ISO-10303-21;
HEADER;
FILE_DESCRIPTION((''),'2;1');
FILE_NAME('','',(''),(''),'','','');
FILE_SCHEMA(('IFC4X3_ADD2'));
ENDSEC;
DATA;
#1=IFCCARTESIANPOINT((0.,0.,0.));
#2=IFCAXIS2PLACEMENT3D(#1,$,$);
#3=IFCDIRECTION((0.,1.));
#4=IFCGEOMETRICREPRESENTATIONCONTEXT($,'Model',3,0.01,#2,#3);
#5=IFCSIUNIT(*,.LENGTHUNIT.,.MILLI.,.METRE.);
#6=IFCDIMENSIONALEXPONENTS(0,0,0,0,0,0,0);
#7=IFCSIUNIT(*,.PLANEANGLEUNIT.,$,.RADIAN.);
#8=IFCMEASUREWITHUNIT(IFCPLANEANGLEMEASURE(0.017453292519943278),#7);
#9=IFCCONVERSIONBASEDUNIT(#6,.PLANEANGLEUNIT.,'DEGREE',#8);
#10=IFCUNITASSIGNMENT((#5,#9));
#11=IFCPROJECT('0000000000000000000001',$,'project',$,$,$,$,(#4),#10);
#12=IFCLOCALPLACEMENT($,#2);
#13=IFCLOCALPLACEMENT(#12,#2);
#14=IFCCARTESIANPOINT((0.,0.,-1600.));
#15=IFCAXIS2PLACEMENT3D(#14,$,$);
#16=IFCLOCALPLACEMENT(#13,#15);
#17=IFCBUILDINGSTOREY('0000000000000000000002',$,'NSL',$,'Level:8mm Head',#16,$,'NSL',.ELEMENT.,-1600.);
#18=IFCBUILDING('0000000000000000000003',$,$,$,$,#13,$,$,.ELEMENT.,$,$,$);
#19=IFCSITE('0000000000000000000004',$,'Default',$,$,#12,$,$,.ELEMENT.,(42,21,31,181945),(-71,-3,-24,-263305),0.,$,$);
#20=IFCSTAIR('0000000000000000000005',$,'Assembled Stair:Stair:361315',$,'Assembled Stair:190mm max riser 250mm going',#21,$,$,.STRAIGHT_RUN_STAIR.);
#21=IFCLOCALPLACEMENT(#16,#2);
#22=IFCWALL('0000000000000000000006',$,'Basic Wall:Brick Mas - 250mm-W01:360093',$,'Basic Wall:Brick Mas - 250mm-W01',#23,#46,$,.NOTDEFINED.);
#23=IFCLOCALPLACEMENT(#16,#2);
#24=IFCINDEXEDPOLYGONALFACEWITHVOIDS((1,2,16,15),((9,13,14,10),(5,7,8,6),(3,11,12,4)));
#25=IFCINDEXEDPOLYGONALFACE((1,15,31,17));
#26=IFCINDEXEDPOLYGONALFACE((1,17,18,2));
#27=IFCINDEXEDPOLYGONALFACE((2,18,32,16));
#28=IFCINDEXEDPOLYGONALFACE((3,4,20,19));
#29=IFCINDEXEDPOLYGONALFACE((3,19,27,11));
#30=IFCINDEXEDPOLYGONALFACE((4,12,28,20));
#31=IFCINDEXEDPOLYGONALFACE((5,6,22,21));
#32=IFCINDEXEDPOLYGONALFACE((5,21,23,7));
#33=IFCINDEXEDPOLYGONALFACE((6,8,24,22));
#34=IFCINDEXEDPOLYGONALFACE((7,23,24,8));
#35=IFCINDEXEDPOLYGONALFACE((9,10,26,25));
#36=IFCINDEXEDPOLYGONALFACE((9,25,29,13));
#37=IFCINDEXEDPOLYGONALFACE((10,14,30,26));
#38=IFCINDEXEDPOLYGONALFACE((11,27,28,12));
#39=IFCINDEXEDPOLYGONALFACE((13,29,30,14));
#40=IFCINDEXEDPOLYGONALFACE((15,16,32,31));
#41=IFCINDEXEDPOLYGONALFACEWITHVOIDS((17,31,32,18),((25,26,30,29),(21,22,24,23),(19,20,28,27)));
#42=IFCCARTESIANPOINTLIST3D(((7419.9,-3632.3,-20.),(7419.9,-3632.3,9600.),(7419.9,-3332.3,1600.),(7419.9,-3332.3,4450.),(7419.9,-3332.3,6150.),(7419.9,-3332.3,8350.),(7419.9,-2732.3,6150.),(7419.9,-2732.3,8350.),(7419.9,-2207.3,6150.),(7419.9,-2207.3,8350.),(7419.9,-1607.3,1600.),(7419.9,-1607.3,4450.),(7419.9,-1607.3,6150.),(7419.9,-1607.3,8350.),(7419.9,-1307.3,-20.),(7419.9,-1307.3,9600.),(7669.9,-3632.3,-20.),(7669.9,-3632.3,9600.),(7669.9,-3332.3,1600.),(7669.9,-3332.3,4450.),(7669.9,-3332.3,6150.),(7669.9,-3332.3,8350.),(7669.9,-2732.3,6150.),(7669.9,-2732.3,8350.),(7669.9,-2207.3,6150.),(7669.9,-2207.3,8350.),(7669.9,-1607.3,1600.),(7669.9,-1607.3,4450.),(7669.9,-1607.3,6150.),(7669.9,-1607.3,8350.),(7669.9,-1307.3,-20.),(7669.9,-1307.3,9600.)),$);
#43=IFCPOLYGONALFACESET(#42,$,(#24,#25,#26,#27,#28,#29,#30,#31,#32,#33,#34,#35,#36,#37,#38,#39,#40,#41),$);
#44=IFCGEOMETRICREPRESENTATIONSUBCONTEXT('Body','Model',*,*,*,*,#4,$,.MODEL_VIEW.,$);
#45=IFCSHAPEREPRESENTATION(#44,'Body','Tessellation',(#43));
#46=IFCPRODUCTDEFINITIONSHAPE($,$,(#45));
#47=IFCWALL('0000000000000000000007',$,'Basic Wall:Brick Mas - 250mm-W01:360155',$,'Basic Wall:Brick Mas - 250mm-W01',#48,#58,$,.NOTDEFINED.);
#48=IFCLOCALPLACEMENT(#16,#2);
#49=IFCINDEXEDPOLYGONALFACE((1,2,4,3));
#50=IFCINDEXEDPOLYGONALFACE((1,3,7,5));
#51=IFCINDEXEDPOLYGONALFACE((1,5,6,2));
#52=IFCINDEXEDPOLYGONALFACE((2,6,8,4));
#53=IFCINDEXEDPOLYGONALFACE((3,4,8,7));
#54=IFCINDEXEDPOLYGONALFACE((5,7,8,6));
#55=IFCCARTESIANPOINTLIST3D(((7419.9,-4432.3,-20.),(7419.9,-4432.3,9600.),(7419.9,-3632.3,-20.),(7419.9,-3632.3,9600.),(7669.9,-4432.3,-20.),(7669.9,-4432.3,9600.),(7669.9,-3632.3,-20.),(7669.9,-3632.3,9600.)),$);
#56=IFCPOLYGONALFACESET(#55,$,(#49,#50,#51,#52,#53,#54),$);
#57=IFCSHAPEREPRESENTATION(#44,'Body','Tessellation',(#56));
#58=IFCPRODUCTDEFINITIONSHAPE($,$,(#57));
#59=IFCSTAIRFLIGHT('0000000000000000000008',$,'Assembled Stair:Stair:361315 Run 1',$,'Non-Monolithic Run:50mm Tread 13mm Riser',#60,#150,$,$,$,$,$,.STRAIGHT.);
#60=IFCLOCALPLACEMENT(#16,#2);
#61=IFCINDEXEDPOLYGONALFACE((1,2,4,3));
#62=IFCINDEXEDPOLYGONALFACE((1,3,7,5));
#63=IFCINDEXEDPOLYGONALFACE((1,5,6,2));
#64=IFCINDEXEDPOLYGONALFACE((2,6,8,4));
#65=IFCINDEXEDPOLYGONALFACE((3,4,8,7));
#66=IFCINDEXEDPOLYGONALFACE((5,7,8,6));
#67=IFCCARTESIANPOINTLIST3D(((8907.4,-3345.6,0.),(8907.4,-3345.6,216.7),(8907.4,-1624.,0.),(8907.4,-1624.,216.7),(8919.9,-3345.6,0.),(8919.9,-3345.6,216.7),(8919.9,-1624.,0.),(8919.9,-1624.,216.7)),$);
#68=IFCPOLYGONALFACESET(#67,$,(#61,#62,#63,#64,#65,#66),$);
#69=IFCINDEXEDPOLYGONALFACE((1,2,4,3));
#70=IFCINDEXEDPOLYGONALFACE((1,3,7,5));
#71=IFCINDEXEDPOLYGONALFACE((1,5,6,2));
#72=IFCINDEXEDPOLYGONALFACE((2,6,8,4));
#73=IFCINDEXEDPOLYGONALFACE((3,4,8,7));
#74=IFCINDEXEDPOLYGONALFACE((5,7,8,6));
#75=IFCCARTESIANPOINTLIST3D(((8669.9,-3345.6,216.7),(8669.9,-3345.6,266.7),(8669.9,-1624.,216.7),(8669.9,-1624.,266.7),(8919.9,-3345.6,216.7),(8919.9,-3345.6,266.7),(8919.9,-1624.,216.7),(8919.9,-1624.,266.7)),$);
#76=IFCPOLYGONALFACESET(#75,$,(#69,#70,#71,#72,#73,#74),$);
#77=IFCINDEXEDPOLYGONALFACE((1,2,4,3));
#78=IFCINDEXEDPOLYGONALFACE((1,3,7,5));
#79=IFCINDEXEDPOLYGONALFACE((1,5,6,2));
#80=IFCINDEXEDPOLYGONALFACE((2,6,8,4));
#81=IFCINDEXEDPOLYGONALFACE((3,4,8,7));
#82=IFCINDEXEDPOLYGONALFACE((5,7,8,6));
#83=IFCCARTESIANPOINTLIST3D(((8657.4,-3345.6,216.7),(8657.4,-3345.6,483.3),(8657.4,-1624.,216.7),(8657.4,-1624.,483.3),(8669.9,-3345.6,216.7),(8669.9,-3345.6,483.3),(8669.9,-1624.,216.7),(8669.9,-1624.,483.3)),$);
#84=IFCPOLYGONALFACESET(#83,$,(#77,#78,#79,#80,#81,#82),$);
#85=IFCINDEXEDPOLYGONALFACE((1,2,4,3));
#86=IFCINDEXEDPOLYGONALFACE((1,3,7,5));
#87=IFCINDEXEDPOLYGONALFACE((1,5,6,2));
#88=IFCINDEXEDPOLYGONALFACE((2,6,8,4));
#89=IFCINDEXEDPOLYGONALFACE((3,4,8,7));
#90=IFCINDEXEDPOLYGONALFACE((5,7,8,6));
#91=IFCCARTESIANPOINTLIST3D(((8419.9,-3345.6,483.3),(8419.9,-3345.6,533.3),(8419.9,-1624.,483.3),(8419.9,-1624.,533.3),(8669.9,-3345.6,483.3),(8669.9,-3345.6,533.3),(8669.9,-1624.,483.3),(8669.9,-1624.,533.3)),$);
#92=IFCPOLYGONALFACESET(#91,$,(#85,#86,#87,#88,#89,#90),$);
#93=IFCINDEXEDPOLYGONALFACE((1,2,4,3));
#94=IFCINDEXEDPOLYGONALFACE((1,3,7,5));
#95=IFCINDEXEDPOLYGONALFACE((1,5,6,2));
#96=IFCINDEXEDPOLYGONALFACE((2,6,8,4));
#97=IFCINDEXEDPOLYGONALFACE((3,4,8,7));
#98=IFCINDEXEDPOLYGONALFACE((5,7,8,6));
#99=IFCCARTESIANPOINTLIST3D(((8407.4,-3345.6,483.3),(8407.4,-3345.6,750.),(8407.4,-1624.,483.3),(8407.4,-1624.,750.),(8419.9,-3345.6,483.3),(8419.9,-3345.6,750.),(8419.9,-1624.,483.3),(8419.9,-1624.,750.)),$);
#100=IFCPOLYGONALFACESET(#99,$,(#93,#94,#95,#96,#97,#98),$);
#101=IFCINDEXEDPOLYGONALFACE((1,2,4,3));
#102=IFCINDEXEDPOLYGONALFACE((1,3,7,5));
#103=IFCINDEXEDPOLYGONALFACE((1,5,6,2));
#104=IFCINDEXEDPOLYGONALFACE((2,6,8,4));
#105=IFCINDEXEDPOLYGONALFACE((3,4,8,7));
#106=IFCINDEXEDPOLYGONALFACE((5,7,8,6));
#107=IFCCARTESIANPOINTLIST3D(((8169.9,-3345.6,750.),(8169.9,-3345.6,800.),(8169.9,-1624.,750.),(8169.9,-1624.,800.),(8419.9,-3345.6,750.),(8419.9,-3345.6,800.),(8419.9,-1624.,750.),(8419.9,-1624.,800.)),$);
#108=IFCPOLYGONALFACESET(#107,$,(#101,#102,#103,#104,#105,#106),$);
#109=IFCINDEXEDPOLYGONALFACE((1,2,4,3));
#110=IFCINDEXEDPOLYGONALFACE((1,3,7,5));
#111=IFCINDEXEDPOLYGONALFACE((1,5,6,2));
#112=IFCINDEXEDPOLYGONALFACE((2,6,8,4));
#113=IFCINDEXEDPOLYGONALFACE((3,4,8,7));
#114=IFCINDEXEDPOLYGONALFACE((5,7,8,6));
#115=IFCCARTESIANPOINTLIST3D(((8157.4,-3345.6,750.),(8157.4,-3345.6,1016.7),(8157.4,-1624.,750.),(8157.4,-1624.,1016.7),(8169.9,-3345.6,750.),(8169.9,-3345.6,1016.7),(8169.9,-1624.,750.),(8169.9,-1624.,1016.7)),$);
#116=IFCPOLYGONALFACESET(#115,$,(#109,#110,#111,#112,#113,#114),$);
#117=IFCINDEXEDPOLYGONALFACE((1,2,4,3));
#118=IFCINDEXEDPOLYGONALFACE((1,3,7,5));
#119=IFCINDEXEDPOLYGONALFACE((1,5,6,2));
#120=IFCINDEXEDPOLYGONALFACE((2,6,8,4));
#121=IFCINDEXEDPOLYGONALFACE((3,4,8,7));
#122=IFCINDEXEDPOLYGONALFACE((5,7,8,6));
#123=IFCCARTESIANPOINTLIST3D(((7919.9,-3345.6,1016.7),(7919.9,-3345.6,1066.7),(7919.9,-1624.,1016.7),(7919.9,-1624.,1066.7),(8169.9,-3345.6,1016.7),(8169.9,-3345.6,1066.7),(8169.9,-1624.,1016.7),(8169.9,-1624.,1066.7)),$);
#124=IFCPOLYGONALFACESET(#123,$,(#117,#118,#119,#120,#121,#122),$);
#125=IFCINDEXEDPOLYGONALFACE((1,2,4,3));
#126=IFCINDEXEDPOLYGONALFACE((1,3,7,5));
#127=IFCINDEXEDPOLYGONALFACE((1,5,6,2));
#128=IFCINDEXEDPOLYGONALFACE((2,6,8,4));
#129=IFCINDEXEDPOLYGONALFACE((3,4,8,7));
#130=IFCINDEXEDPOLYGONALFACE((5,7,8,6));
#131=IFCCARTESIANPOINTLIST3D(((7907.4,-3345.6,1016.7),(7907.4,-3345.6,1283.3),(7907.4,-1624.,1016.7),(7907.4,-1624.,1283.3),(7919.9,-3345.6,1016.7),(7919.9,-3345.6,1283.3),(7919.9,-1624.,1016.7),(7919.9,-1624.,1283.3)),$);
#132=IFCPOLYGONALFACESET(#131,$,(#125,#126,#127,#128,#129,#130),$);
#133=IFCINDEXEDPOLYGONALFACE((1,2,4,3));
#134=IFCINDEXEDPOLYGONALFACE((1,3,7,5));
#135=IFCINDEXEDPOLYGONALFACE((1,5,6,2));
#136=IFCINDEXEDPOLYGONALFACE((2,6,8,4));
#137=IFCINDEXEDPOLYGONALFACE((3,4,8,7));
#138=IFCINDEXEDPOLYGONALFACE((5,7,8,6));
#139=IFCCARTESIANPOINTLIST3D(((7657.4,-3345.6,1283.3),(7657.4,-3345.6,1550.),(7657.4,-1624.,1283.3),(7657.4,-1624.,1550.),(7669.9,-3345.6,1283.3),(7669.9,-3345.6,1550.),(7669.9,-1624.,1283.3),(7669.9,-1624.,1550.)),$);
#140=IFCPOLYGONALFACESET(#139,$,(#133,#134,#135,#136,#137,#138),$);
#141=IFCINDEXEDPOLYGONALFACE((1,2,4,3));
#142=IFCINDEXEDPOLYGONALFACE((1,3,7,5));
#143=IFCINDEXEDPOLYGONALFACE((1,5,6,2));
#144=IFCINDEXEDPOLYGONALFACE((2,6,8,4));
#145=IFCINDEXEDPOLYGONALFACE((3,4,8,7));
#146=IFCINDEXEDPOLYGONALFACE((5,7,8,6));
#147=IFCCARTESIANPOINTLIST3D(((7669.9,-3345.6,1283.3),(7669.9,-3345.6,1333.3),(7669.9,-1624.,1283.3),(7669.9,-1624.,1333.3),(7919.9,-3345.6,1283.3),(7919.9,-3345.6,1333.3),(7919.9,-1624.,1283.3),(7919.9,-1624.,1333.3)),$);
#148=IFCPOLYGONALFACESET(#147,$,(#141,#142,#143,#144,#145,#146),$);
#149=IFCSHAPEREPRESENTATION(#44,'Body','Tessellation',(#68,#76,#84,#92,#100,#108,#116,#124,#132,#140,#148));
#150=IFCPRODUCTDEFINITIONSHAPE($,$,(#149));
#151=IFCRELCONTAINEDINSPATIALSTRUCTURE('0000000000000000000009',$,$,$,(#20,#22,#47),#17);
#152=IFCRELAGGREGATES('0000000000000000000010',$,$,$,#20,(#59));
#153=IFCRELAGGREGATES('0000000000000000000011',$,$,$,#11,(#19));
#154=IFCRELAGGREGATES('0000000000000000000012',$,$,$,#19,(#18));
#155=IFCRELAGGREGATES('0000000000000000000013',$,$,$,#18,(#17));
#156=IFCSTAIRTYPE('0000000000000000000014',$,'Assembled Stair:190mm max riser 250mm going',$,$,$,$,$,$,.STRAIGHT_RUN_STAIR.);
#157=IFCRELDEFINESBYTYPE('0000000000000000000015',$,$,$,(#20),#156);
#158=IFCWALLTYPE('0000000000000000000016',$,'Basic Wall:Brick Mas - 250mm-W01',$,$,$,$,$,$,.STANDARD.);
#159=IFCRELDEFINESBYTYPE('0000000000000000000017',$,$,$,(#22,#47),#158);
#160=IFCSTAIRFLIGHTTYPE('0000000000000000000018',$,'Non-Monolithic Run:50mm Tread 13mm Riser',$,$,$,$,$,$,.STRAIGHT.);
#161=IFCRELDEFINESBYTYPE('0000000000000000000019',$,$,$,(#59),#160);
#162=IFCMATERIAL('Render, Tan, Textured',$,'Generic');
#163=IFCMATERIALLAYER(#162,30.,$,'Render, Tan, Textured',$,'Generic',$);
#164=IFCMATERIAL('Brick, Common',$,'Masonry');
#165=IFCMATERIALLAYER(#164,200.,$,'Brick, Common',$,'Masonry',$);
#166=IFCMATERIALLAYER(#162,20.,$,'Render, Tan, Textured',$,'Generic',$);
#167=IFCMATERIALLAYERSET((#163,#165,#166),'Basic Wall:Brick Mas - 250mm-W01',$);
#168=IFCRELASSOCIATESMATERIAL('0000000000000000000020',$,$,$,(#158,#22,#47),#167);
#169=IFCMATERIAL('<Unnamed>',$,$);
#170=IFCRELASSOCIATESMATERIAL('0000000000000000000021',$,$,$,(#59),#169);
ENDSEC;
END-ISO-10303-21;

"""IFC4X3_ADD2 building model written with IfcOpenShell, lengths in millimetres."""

from ifc_helpers import new_model, entity, si_unit, converted_unit, direction, frame, frame_2d, origin, origin_2d_with_axis, place, context, subcontext, project, spatial, rectangle, extrude, material, layer, layer_set, type_object, element, aggregate, save


model = new_model("IFC4X3_ADD2")

# Units and contexts
model_context = context("Model", 3, precision=0.01, world=origin(), true_north=direction((0.0, 1.0)))
body_context = subcontext(model_context, "Body", "Model", "MODEL_VIEW")
ifc_project = project(units=[si_unit("LENGTHUNIT", "METRE", prefix="MILLI"), converted_unit("PLANEANGLEUNIT", "DEGREE", entity("IfcPlaneAngleMeasure", 0.017453292519943278), si_unit("PLANEANGLEUNIT", "RADIAN"), dimensions=[0, 0, 0, 0, 0, 0, 0])], contexts=[model_context])

# Site, building, storey
site_placement = place(None, origin())
site = spatial("IfcSite", under=ifc_project, at=site_placement, Name="Default", CompositionType="ELEMENT", RefLatitude=(42, 21, 31, 181945), RefLongitude=(-71, -3, -24, -263305), RefElevation=0.0)
building_placement = place(site_placement, origin())
building = spatial("IfcBuilding", under=site, at=building_placement, CompositionType="ELEMENT")
storey_placement = place(building_placement, frame((0.0, 0.0, -1600.0)))
storey = spatial("IfcBuildingStorey", under=building, at=storey_placement, Name="NSL", ObjectType="Level:8mm Head", LongName="NSL", CompositionType="ELEMENT", Elevation=-1600.0)

# Stair
stair_type = type_object("IfcStairType", Name="Assembled Stair:190mm max riser 250mm going", PredefinedType="STRAIGHT_RUN_STAIR")
stair_placement = place(storey_placement, origin())
stair = element("IfcStair", 1, at=stair_placement, inside=storey, type_object=stair_type, Name="Assembled Stair:Stair:361315", ObjectType="Assembled Stair:190mm max riser 250mm going", PredefinedType="STRAIGHT_RUN_STAIR")
ifc_material_1 = material(Name="<Unnamed>")

# Shared definitions
ifc_material_2 = material(Name="Render, Tan, Textured", Category="Generic")
ifc_layer_1 = layer(ifc_material_2, 30.0, Name="Render, Tan, Textured", Category="Generic")
ifc_material_3 = material(Name="Brick, Common", Category="Masonry")
ifc_layer_2 = layer(ifc_material_3, 200.0, Name="Brick, Common", Category="Masonry")
ifc_layer_3 = layer(ifc_material_2, 20.0, Name="Render, Tan, Textured", Category="Generic")
ifc_layer_set = layer_set([ifc_layer_1, ifc_layer_2, ifc_layer_3], Name="Basic Wall:Brick Mas - 250mm-W01")
wall_type = type_object("IfcWallType", Name="Basic Wall:Brick Mas - 250mm-W01", PredefinedType="STANDARD", material=ifc_layer_set)

# Wall, openings
wall_1_placement = place(storey_placement, frame((7544.9, -1307.3, -20.0), z_axis=(0.0, 0.0, 1.0), x_axis=(0.0, -1.0, 0.0)))
wall_1 = element("IfcWall", 2, at=wall_1_placement, inside=storey, type_object=wall_type, material=ifc_layer_set, Name="Basic Wall:Brick Mas - 250mm-W01:360093", ObjectType="Basic Wall:Brick Mas - 250mm-W01", PredefinedType="NOTDEFINED", context=body_context, shape_type="SweptSolid", body=[
    extrude(rectangle(XDim=2325.0, YDim=250.0, at=frame_2d((1162.5, 0.0), x_axis=(-1.0, 0.0))), origin(), (0.0, 0.0, 1.0), 9620.0),
])
opening_1_placement = place(wall_1_placement, origin())
element("IfcOpeningElement", 3, at=opening_1_placement, cuts=wall_1, PredefinedType="OPENING", context=body_context, shape_type="SweptSolid", body=[
    extrude(rectangle(XDim=2850.0, YDim=1725.0, at=origin_2d_with_axis()), frame((1162.5, 125.0, 3045.0), z_axis=(0.0, 1.0, 0.0), x_axis=(0.0, 0.0, 1.0)), (0.0, 0.0, -1.0), 250.0),
])
opening_2_placement = place(wall_1_placement, origin())
element("IfcOpeningElement", 4, at=opening_2_placement, cuts=wall_1, PredefinedType="OPENING", context=body_context, shape_type="SweptSolid", body=[
    extrude(rectangle(XDim=2200.0, YDim=600.0, at=frame_2d((0.0, 0.0), x_axis=(1.0, 0.0))), frame((1725.0, 125.0, 7270.0), z_axis=(0.0, -1.0, 0.0), x_axis=(0.0, 0.0, -1.0)), (0.0, 0.0, 1.0), 250.0),
])
opening_3_placement = place(wall_1_placement, origin())
element("IfcOpeningElement", 5, at=opening_3_placement, cuts=wall_1, PredefinedType="OPENING", context=body_context, shape_type="SweptSolid", body=[
    extrude(rectangle(XDim=2200.0, YDim=600.0, at=origin_2d_with_axis()), frame((600.0, 125.0, 7270.0), z_axis=(0.0, -1.0, 0.0), x_axis=(0.0, 0.0, -1.0)), (0.0, 0.0, 1.0), 250.0),
])

# Wall
wall_2_placement = place(storey_placement, frame((7544.9, -3632.3, -20.0), z_axis=(0.0, 0.0, 1.0), x_axis=(0.0, -1.0, 0.0)))
element("IfcWall", 6, at=wall_2_placement, inside=storey, type_object=wall_type, material=ifc_layer_set, Name="Basic Wall:Brick Mas - 250mm-W01:360155", ObjectType="Basic Wall:Brick Mas - 250mm-W01", PredefinedType="NOTDEFINED", context=body_context, shape_type="SweptSolid", body=[
    extrude(rectangle(XDim=800.0, YDim=250.0, at=frame_2d((400.0, 0.0), x_axis=(-1.0, 0.0))), origin(), (0.0, 0.0, 1.0), 9620.0),
])

# Stair flight
stair_flight_type = type_object("IfcStairFlightType", Name="Non-Monolithic Run:50mm Tread 13mm Riser", PredefinedType="STRAIGHT")
stair_flight_placement = place(stair_placement, frame((7657.4, -3345.6, 0.0)))
stair_flight = element("IfcStairFlight", 7, at=stair_flight_placement, type_object=stair_flight_type, material=ifc_material_1, Name="Assembled Stair:Stair:361315 Run 1", ObjectType="Non-Monolithic Run:50mm Tread 13mm Riser", PredefinedType="STRAIGHT", context=body_context, shape_type="SweptSolid", body=[
    extrude(rectangle(XDim=1721.7, YDim=12.5, at=origin_2d_with_axis()), frame((1256.3, 860.8, 0.0), z_axis=(0.0, 0.0, 1.0), x_axis=(0.0, -1.0, 0.0)), (0.0, 0.0, 1.0), 216.7),
    extrude(rectangle(XDim=250.0, YDim=1721.7, at=frame_2d((0.0, 0.0), x_axis=(1.0, 0.0))), frame((1137.5, 860.8, 216.7)), (0.0, 0.0, 1.0), 50.0),
    extrude(rectangle(XDim=1721.7, YDim=12.5, at=frame_2d((0.0, 0.0), x_axis=(1.0, 0.0))), frame((1006.3, 860.8, 216.7), z_axis=(0.0, 0.0, 1.0), x_axis=(0.0, -1.0, 0.0)), (0.0, 0.0, 1.0), 266.7),
    extrude(rectangle(XDim=250.0, YDim=1721.7, at=frame_2d((0.0, 0.0), x_axis=(1.0, 0.0))), frame((887.5, 860.8, 483.3)), (0.0, 0.0, 1.0), 50.0),
    extrude(rectangle(XDim=1721.7, YDim=12.5, at=origin_2d_with_axis()), frame((756.3, 860.8, 483.3), z_axis=(0.0, 0.0, 1.0), x_axis=(0.0, -1.0, 0.0)), (0.0, 0.0, 1.0), 266.7),
    extrude(rectangle(XDim=250.0, YDim=1721.7, at=origin_2d_with_axis()), frame((637.5, 860.8, 750.0)), (0.0, 0.0, 1.0), 50.0),
    extrude(rectangle(XDim=1721.7, YDim=12.5, at=frame_2d((0.0, 0.0), x_axis=(1.0, 0.0))), frame((506.3, 860.8, 750.0), z_axis=(0.0, 0.0, 1.0), x_axis=(0.0, -1.0, 0.0)), (0.0, 0.0, 1.0), 266.7),
    extrude(rectangle(XDim=250.0, YDim=1721.7, at=origin_2d_with_axis()), frame((387.5, 860.8, 1016.7)), (0.0, 0.0, 1.0), 50.0),
    extrude(rectangle(XDim=1721.7, YDim=12.5, at=origin_2d_with_axis()), frame((256.3, 860.8, 1016.7), z_axis=(0.0, 0.0, 1.0), x_axis=(0.0, -1.0, 0.0)), (0.0, 0.0, 1.0), 266.7),
    extrude(rectangle(XDim=1721.7, YDim=12.5, at=origin_2d_with_axis()), frame((6.3, 860.8, 1283.3), z_axis=(0.0, 0.0, 1.0), x_axis=(0.0, -1.0, 0.0)), (0.0, 0.0, 1.0), 266.7),
    extrude(rectangle(XDim=250.0, YDim=1721.7, at=frame_2d((0.0, 0.0), x_axis=(1.0, 0.0))), frame((137.5, 860.8, 1283.3)), (0.0, 0.0, 1.0), 50.0),
])

aggregate(stair, [stair_flight])

save(model, "model.ifc")
